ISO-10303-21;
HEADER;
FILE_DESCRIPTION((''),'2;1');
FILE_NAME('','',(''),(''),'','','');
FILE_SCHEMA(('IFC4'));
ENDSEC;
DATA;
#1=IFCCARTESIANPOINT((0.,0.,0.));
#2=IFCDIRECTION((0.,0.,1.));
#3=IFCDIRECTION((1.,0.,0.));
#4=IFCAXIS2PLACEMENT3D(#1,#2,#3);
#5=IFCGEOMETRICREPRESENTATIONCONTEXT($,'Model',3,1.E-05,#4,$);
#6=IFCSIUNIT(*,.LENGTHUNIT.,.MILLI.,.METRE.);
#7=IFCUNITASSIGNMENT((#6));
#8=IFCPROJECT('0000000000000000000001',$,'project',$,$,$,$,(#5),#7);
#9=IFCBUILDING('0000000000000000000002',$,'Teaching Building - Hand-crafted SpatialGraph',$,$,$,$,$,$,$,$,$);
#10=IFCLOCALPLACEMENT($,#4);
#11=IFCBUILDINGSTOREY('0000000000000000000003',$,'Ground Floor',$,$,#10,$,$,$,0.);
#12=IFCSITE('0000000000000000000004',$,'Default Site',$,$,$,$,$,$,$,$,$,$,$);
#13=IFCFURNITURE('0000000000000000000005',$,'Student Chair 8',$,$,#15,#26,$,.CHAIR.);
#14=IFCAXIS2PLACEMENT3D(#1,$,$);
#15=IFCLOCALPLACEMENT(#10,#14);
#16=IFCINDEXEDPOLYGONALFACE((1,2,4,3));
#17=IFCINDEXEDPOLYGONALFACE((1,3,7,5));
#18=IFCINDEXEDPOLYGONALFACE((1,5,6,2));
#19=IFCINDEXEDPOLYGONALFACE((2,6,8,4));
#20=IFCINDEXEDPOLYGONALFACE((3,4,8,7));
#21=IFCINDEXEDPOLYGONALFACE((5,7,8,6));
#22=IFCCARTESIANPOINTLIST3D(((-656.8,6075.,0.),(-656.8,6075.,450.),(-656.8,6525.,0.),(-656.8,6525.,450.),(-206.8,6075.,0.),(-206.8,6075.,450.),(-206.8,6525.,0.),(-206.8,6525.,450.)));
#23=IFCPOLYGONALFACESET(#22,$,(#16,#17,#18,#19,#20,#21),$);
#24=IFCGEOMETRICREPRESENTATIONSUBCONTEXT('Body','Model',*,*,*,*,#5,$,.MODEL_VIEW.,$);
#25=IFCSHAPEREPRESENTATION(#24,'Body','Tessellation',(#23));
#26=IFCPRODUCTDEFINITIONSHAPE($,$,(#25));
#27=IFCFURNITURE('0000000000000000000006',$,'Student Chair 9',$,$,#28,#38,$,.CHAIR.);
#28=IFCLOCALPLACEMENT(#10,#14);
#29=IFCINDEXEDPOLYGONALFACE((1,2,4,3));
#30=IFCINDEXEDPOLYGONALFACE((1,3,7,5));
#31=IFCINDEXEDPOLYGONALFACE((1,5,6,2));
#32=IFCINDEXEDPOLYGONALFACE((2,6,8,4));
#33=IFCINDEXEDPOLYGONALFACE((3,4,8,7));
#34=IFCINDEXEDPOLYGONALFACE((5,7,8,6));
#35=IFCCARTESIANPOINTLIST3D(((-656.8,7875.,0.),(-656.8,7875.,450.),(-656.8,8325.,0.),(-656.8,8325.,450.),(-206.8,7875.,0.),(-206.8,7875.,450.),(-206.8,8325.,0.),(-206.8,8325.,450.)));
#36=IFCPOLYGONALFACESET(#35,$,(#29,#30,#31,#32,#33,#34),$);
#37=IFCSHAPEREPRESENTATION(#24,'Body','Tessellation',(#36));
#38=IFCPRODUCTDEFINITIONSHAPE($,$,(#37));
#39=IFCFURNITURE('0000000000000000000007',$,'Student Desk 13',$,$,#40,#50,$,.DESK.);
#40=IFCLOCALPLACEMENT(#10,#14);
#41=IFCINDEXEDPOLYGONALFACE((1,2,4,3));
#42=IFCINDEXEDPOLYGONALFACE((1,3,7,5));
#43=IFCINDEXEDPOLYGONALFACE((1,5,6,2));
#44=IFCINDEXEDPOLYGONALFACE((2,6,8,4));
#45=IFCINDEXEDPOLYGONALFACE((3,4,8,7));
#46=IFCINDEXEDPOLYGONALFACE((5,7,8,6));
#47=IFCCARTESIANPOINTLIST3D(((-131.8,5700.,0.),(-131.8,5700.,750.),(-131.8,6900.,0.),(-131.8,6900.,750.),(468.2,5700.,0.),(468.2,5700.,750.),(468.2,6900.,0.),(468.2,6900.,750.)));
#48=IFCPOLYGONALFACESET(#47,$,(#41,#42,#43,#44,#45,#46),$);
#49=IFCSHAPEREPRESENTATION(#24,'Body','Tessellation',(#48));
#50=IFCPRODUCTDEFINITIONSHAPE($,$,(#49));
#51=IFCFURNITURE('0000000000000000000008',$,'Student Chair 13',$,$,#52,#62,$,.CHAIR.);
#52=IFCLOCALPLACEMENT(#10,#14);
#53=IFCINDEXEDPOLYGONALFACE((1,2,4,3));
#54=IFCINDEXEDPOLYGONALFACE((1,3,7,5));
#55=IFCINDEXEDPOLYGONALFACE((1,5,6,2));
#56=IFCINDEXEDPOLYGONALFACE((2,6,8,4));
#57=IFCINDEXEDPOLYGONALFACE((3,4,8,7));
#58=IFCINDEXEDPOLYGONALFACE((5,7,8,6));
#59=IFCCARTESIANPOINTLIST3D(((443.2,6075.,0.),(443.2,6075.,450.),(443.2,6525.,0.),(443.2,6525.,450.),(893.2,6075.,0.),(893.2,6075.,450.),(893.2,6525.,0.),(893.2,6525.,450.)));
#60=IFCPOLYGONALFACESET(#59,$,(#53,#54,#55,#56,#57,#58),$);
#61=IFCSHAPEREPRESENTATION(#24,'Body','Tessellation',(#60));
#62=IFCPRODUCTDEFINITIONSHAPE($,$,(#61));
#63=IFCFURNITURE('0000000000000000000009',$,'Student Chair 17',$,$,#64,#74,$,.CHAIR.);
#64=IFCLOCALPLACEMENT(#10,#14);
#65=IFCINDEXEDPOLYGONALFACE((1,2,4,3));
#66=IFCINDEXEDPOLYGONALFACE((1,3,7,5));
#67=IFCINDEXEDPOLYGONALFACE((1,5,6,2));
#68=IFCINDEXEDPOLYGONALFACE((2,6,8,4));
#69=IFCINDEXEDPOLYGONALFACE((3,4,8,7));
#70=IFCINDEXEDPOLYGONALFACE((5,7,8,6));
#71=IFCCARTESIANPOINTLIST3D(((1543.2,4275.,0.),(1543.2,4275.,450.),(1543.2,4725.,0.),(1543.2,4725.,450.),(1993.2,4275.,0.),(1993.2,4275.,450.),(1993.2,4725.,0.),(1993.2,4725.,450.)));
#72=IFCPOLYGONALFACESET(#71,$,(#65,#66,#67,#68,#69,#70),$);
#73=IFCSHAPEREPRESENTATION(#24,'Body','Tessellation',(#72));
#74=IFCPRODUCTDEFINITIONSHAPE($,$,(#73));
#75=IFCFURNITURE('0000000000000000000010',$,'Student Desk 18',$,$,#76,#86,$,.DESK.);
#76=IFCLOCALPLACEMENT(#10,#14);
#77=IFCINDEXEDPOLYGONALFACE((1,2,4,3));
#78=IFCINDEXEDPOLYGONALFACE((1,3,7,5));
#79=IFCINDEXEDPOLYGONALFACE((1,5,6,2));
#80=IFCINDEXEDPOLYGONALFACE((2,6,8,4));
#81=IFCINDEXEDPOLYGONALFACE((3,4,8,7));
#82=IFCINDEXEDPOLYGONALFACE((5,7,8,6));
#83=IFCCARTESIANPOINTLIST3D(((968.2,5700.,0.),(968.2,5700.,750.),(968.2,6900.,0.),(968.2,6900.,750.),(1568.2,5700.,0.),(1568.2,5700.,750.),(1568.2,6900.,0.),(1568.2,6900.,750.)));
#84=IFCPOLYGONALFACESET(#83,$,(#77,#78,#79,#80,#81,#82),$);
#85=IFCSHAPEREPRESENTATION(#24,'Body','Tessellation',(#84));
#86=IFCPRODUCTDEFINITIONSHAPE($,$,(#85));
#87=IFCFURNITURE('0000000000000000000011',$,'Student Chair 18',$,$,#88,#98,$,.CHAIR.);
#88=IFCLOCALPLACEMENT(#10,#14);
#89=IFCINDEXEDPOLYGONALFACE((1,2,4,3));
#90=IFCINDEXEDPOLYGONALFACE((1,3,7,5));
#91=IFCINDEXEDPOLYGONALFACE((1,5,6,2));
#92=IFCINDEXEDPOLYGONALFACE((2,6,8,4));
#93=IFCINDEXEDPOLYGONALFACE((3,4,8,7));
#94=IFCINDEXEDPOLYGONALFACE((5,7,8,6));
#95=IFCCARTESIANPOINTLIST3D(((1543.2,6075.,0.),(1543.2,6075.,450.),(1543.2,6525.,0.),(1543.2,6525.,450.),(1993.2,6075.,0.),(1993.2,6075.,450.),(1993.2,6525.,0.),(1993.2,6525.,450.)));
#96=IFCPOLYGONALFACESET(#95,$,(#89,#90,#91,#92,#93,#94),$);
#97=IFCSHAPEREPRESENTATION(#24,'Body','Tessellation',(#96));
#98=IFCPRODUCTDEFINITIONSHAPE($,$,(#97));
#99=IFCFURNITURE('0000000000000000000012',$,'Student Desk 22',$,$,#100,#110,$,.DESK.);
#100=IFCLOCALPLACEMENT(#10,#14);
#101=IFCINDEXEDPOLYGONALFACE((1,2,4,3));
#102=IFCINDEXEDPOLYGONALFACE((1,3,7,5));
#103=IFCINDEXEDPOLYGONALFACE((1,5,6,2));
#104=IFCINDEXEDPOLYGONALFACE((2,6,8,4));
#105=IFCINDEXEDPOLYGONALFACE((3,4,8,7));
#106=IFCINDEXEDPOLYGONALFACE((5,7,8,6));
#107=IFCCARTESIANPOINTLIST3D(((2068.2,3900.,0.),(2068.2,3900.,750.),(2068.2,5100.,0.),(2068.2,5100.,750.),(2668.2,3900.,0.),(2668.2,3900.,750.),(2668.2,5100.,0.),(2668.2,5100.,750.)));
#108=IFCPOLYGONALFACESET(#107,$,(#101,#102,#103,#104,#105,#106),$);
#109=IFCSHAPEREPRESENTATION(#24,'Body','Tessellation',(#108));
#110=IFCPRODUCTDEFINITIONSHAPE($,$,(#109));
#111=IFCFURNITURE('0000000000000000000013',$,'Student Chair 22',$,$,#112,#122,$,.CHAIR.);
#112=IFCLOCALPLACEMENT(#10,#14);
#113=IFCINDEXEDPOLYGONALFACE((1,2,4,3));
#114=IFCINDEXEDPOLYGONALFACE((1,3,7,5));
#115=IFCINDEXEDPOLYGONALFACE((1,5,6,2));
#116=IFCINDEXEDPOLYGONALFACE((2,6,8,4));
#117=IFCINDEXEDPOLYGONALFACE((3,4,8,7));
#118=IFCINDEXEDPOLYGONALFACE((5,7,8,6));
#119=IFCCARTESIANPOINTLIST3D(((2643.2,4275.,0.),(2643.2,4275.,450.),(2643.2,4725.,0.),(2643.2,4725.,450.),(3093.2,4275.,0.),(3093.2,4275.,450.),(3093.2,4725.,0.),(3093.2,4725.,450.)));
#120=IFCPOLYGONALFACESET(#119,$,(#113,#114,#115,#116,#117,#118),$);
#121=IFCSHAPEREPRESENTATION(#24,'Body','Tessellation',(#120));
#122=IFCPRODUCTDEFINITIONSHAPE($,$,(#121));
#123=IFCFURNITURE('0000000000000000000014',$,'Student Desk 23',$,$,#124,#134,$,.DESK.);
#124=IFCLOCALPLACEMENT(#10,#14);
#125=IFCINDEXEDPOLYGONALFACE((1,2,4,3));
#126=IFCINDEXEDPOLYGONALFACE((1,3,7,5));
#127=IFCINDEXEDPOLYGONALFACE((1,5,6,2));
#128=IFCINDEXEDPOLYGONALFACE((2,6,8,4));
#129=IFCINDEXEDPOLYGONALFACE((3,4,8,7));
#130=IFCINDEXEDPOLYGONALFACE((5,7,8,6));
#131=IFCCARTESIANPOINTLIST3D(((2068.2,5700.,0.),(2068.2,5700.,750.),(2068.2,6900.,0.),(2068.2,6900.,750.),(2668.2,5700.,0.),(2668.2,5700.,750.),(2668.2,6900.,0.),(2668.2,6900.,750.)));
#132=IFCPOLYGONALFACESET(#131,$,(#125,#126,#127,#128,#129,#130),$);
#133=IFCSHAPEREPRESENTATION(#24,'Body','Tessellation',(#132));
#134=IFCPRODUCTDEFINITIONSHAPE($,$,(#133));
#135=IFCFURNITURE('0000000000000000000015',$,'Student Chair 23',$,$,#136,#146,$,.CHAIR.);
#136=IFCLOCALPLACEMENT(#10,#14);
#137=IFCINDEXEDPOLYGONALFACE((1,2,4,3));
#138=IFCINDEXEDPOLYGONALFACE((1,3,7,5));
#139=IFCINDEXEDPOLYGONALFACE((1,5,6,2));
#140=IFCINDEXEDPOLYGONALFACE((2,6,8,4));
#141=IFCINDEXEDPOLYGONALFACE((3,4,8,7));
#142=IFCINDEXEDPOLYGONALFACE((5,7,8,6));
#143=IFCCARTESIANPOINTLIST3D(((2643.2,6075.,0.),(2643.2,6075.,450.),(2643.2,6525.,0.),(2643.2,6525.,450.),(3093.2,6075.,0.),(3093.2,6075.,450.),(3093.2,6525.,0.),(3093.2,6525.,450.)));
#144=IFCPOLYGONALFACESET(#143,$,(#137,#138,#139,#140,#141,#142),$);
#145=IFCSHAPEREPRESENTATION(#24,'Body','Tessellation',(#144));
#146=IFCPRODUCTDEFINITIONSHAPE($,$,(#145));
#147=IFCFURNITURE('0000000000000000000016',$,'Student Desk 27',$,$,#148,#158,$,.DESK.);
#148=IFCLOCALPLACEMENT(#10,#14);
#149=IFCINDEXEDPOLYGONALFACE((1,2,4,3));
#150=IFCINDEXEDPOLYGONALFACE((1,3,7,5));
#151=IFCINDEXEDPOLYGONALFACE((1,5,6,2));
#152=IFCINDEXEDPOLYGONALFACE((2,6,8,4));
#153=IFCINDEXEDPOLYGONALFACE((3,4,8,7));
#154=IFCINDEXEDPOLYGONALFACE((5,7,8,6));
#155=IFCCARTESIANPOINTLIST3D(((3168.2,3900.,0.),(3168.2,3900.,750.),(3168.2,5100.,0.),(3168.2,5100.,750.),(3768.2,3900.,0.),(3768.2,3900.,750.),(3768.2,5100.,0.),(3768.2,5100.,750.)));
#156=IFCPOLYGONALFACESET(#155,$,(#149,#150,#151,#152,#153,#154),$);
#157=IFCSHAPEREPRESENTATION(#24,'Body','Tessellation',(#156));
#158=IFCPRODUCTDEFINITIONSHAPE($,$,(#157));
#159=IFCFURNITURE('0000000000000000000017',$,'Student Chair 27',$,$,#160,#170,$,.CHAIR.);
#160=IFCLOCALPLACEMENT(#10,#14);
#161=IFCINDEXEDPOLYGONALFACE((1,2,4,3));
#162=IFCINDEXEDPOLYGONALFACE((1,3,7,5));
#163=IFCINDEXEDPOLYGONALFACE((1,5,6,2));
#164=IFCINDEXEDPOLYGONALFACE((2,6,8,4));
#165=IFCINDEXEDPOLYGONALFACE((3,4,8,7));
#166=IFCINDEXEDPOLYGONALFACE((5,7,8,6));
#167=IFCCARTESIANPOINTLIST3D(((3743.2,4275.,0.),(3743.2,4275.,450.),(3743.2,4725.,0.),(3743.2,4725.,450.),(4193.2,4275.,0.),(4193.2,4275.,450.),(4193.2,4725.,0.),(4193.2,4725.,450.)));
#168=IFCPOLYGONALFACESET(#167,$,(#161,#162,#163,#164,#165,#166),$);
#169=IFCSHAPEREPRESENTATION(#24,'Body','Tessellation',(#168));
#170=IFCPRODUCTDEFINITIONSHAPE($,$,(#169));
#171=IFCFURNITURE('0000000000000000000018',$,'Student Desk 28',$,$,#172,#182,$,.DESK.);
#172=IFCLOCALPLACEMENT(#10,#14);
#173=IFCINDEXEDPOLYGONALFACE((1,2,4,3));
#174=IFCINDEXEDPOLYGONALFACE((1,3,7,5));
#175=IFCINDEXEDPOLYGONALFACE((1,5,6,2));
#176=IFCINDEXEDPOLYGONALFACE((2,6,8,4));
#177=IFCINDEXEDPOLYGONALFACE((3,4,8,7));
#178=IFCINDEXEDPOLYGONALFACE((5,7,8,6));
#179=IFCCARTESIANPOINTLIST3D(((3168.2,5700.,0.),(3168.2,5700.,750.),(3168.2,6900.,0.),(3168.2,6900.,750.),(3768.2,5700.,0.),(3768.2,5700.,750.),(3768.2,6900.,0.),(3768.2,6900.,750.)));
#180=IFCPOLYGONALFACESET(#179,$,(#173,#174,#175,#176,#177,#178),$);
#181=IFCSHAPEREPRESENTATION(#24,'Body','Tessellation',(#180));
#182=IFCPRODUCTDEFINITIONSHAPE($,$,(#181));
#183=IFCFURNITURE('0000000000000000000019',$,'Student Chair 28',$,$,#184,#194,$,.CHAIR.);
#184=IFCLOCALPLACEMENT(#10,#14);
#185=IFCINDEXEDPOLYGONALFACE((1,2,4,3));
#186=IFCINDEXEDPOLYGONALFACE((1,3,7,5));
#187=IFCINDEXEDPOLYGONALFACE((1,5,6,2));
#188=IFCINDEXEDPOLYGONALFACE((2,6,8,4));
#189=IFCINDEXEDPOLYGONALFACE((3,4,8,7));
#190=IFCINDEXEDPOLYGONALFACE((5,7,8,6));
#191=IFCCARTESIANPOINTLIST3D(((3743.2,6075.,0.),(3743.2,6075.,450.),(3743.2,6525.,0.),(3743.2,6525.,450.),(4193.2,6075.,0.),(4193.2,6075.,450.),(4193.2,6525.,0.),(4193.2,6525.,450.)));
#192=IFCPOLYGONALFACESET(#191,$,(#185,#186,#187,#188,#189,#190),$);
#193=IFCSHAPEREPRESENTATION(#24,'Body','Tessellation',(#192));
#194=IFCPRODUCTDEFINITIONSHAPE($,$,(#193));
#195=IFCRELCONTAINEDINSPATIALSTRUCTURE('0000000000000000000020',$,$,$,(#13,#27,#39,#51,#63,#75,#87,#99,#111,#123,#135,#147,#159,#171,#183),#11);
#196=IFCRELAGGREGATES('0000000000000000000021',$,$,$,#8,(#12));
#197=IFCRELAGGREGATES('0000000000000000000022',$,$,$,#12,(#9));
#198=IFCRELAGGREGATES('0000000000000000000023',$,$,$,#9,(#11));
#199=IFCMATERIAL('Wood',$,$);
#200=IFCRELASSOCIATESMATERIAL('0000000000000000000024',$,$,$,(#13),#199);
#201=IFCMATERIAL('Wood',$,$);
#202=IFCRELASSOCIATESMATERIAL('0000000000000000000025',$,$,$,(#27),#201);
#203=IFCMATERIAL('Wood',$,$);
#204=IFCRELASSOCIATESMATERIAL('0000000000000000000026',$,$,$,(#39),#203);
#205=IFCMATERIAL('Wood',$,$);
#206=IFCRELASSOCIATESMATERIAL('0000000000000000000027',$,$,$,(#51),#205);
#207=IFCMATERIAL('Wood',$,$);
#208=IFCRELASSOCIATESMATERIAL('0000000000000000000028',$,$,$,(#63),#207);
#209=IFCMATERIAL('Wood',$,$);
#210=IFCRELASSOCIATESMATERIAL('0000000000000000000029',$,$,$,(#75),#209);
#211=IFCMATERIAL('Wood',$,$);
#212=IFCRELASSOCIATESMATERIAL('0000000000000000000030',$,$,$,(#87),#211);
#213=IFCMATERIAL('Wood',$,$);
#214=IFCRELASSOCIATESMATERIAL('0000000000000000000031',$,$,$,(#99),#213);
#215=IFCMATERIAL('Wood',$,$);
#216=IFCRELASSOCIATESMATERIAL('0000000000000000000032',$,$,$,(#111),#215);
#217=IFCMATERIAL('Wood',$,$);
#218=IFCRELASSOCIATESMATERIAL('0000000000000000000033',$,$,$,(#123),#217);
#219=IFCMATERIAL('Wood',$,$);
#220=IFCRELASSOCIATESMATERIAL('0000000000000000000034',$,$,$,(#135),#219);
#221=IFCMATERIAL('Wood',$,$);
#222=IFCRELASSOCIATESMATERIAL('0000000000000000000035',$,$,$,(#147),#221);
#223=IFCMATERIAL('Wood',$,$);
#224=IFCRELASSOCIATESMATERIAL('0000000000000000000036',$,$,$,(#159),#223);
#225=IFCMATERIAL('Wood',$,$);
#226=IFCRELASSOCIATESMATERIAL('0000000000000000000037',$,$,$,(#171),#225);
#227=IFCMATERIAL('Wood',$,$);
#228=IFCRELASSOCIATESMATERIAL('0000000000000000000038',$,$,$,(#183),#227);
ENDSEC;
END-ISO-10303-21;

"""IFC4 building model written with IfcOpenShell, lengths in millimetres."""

from ifc_helpers import new_model, si_unit, frame, origin_with_axes, origin_2d, place, context, subcontext, project, spatial, rectangle, extrude, material, element, save


model = new_model("IFC4")

# Units and contexts
model_context = context("Model", 3, precision=1e-05, world=origin_with_axes())
body_context = subcontext(model_context, "Body", "Model", "MODEL_VIEW")
ifc_project = project(units=[si_unit("LENGTHUNIT", "METRE", prefix="MILLI")], contexts=[model_context])

# Site, building, storey
site = spatial("IfcSite", under=ifc_project, Name="Default Site")
building = spatial("IfcBuilding", under=site, Name="Teaching Building - Hand-crafted SpatialGraph")
storey_placement = place(None, origin_with_axes())
storey = spatial("IfcBuildingStorey", under=building, at=storey_placement, Name="Ground Floor", Elevation=0.0)

# Furniture
ifc_material_1 = material(Name="Wood")
furniture_1_placement = place(storey_placement, frame((-431.8, 6300.0, 0.0), z_axis=(0.0, 0.0, 1.0), x_axis=(1.0, 0.0, 0.0)))
element("IfcFurniture", 1, at=furniture_1_placement, inside=storey, material=ifc_material_1, Name="Student Chair 8", PredefinedType="CHAIR", context=body_context, shape_type="SweptSolid", body=[
    extrude(rectangle(XDim=450.0, YDim=450.0, at=origin_2d()), origin_with_axes(), (0.0, 0.0, 1.0), 450.0),
])
ifc_material_2 = material(Name="Wood")
furniture_2_placement = place(storey_placement, frame((-431.8, 8100.0, 0.0), z_axis=(0.0, 0.0, 1.0), x_axis=(1.0, 0.0, 0.0)))
element("IfcFurniture", 2, at=furniture_2_placement, inside=storey, material=ifc_material_2, Name="Student Chair 9", PredefinedType="CHAIR", context=body_context, shape_type="SweptSolid", body=[
    extrude(rectangle(XDim=450.0, YDim=450.0, at=origin_2d()), origin_with_axes(), (0.0, 0.0, 1.0), 450.0),
])
ifc_material_3 = material(Name="Wood")
furniture_3_placement = place(storey_placement, frame((168.2, 6300.0, 0.0), z_axis=(0.0, 0.0, 1.0), x_axis=(0.0, 1.0, 0.0)))
element("IfcFurniture", 3, at=furniture_3_placement, inside=storey, material=ifc_material_3, Name="Student Desk 13", PredefinedType="DESK", context=body_context, shape_type="SweptSolid", body=[
    extrude(rectangle(XDim=1200.0, YDim=600.0, at=origin_2d()), origin_with_axes(), (0.0, 0.0, 1.0), 750.0),
])
ifc_material_4 = material(Name="Wood")
furniture_4_placement = place(storey_placement, frame((668.2, 6300.0, 0.0), z_axis=(0.0, 0.0, 1.0), x_axis=(1.0, 0.0, 0.0)))
element("IfcFurniture", 4, at=furniture_4_placement, inside=storey, material=ifc_material_4, Name="Student Chair 13", PredefinedType="CHAIR", context=body_context, shape_type="SweptSolid", body=[
    extrude(rectangle(XDim=450.0, YDim=450.0, at=origin_2d()), origin_with_axes(), (0.0, 0.0, 1.0), 450.0),
])
ifc_material_5 = material(Name="Wood")
furniture_5_placement = place(storey_placement, frame((1768.2, 4500.0, 0.0), z_axis=(0.0, 0.0, 1.0), x_axis=(1.0, 0.0, 0.0)))
element("IfcFurniture", 5, at=furniture_5_placement, inside=storey, material=ifc_material_5, Name="Student Chair 17", PredefinedType="CHAIR", context=body_context, shape_type="SweptSolid", body=[
    extrude(rectangle(XDim=450.0, YDim=450.0, at=origin_2d()), origin_with_axes(), (0.0, 0.0, 1.0), 450.0),
])
ifc_material_6 = material(Name="Wood")
furniture_6_placement = place(storey_placement, frame((1268.2, 6300.0, 0.0), z_axis=(0.0, 0.0, 1.0), x_axis=(0.0, 1.0, 0.0)))
element("IfcFurniture", 6, at=furniture_6_placement, inside=storey, material=ifc_material_6, Name="Student Desk 18", PredefinedType="DESK", context=body_context, shape_type="SweptSolid", body=[
    extrude(rectangle(XDim=1200.0, YDim=600.0, at=origin_2d()), origin_with_axes(), (0.0, 0.0, 1.0), 750.0),
])
ifc_material_7 = material(Name="Wood")
furniture_7_placement = place(storey_placement, frame((1768.2, 6300.0, 0.0), z_axis=(0.0, 0.0, 1.0), x_axis=(1.0, 0.0, 0.0)))
element("IfcFurniture", 7, at=furniture_7_placement, inside=storey, material=ifc_material_7, Name="Student Chair 18", PredefinedType="CHAIR", context=body_context, shape_type="SweptSolid", body=[
    extrude(rectangle(XDim=450.0, YDim=450.0, at=origin_2d()), origin_with_axes(), (0.0, 0.0, 1.0), 450.0),
])
ifc_material_8 = material(Name="Wood")
furniture_8_placement = place(storey_placement, frame((2368.2, 4500.0, 0.0), z_axis=(0.0, 0.0, 1.0), x_axis=(0.0, 1.0, 0.0)))
element("IfcFurniture", 8, at=furniture_8_placement, inside=storey, material=ifc_material_8, Name="Student Desk 22", PredefinedType="DESK", context=body_context, shape_type="SweptSolid", body=[
    extrude(rectangle(XDim=1200.0, YDim=600.0, at=origin_2d()), origin_with_axes(), (0.0, 0.0, 1.0), 750.0),
])
ifc_material_9 = material(Name="Wood")
furniture_9_placement = place(storey_placement, frame((2868.2, 4500.0, 0.0), z_axis=(0.0, 0.0, 1.0), x_axis=(1.0, 0.0, 0.0)))
element("IfcFurniture", 9, at=furniture_9_placement, inside=storey, material=ifc_material_9, Name="Student Chair 22", PredefinedType="CHAIR", context=body_context, shape_type="SweptSolid", body=[
    extrude(rectangle(XDim=450.0, YDim=450.0, at=origin_2d()), origin_with_axes(), (0.0, 0.0, 1.0), 450.0),
])
ifc_material_10 = material(Name="Wood")
furniture_10_placement = place(storey_placement, frame((2368.2, 6300.0, 0.0), z_axis=(0.0, 0.0, 1.0), x_axis=(0.0, 1.0, 0.0)))
element("IfcFurniture", 10, at=furniture_10_placement, inside=storey, material=ifc_material_10, Name="Student Desk 23", PredefinedType="DESK", context=body_context, shape_type="SweptSolid", body=[
    extrude(rectangle(XDim=1200.0, YDim=600.0, at=origin_2d()), origin_with_axes(), (0.0, 0.0, 1.0), 750.0),
])
ifc_material_11 = material(Name="Wood")
furniture_11_placement = place(storey_placement, frame((2868.2, 6300.0, 0.0), z_axis=(0.0, 0.0, 1.0), x_axis=(1.0, 0.0, 0.0)))
element("IfcFurniture", 11, at=furniture_11_placement, inside=storey, material=ifc_material_11, Name="Student Chair 23", PredefinedType="CHAIR", context=body_context, shape_type="SweptSolid", body=[
    extrude(rectangle(XDim=450.0, YDim=450.0, at=origin_2d()), origin_with_axes(), (0.0, 0.0, 1.0), 450.0),
])
ifc_material_12 = material(Name="Wood")
furniture_12_placement = place(storey_placement, frame((3468.2, 4500.0, 0.0), z_axis=(0.0, 0.0, 1.0), x_axis=(0.0, 1.0, 0.0)))
element("IfcFurniture", 12, at=furniture_12_placement, inside=storey, material=ifc_material_12, Name="Student Desk 27", PredefinedType="DESK", context=body_context, shape_type="SweptSolid", body=[
    extrude(rectangle(XDim=1200.0, YDim=600.0, at=origin_2d()), origin_with_axes(), (0.0, 0.0, 1.0), 750.0),
])
ifc_material_13 = material(Name="Wood")
furniture_13_placement = place(storey_placement, frame((3968.2, 4500.0, 0.0), z_axis=(0.0, 0.0, 1.0), x_axis=(1.0, 0.0, 0.0)))
element("IfcFurniture", 13, at=furniture_13_placement, inside=storey, material=ifc_material_13, Name="Student Chair 27", PredefinedType="CHAIR", context=body_context, shape_type="SweptSolid", body=[
    extrude(rectangle(XDim=450.0, YDim=450.0, at=origin_2d()), origin_with_axes(), (0.0, 0.0, 1.0), 450.0),
])
ifc_material_14 = material(Name="Wood")
furniture_14_placement = place(storey_placement, frame((3468.2, 6300.0, 0.0), z_axis=(0.0, 0.0, 1.0), x_axis=(0.0, 1.0, 0.0)))
element("IfcFurniture", 14, at=furniture_14_placement, inside=storey, material=ifc_material_14, Name="Student Desk 28", PredefinedType="DESK", context=body_context, shape_type="SweptSolid", body=[
    extrude(rectangle(XDim=1200.0, YDim=600.0, at=origin_2d()), origin_with_axes(), (0.0, 0.0, 1.0), 750.0),
])
ifc_material_15 = material(Name="Wood")
furniture_15_placement = place(storey_placement, frame((3968.2, 6300.0, 0.0), z_axis=(0.0, 0.0, 1.0), x_axis=(1.0, 0.0, 0.0)))
element("IfcFurniture", 15, at=furniture_15_placement, inside=storey, material=ifc_material_15, Name="Student Chair 28", PredefinedType="CHAIR", context=body_context, shape_type="SweptSolid", body=[
    extrude(rectangle(XDim=450.0, YDim=450.0, at=origin_2d()), origin_with_axes(), (0.0, 0.0, 1.0), 450.0),
])

save(model, "model.ifc")
